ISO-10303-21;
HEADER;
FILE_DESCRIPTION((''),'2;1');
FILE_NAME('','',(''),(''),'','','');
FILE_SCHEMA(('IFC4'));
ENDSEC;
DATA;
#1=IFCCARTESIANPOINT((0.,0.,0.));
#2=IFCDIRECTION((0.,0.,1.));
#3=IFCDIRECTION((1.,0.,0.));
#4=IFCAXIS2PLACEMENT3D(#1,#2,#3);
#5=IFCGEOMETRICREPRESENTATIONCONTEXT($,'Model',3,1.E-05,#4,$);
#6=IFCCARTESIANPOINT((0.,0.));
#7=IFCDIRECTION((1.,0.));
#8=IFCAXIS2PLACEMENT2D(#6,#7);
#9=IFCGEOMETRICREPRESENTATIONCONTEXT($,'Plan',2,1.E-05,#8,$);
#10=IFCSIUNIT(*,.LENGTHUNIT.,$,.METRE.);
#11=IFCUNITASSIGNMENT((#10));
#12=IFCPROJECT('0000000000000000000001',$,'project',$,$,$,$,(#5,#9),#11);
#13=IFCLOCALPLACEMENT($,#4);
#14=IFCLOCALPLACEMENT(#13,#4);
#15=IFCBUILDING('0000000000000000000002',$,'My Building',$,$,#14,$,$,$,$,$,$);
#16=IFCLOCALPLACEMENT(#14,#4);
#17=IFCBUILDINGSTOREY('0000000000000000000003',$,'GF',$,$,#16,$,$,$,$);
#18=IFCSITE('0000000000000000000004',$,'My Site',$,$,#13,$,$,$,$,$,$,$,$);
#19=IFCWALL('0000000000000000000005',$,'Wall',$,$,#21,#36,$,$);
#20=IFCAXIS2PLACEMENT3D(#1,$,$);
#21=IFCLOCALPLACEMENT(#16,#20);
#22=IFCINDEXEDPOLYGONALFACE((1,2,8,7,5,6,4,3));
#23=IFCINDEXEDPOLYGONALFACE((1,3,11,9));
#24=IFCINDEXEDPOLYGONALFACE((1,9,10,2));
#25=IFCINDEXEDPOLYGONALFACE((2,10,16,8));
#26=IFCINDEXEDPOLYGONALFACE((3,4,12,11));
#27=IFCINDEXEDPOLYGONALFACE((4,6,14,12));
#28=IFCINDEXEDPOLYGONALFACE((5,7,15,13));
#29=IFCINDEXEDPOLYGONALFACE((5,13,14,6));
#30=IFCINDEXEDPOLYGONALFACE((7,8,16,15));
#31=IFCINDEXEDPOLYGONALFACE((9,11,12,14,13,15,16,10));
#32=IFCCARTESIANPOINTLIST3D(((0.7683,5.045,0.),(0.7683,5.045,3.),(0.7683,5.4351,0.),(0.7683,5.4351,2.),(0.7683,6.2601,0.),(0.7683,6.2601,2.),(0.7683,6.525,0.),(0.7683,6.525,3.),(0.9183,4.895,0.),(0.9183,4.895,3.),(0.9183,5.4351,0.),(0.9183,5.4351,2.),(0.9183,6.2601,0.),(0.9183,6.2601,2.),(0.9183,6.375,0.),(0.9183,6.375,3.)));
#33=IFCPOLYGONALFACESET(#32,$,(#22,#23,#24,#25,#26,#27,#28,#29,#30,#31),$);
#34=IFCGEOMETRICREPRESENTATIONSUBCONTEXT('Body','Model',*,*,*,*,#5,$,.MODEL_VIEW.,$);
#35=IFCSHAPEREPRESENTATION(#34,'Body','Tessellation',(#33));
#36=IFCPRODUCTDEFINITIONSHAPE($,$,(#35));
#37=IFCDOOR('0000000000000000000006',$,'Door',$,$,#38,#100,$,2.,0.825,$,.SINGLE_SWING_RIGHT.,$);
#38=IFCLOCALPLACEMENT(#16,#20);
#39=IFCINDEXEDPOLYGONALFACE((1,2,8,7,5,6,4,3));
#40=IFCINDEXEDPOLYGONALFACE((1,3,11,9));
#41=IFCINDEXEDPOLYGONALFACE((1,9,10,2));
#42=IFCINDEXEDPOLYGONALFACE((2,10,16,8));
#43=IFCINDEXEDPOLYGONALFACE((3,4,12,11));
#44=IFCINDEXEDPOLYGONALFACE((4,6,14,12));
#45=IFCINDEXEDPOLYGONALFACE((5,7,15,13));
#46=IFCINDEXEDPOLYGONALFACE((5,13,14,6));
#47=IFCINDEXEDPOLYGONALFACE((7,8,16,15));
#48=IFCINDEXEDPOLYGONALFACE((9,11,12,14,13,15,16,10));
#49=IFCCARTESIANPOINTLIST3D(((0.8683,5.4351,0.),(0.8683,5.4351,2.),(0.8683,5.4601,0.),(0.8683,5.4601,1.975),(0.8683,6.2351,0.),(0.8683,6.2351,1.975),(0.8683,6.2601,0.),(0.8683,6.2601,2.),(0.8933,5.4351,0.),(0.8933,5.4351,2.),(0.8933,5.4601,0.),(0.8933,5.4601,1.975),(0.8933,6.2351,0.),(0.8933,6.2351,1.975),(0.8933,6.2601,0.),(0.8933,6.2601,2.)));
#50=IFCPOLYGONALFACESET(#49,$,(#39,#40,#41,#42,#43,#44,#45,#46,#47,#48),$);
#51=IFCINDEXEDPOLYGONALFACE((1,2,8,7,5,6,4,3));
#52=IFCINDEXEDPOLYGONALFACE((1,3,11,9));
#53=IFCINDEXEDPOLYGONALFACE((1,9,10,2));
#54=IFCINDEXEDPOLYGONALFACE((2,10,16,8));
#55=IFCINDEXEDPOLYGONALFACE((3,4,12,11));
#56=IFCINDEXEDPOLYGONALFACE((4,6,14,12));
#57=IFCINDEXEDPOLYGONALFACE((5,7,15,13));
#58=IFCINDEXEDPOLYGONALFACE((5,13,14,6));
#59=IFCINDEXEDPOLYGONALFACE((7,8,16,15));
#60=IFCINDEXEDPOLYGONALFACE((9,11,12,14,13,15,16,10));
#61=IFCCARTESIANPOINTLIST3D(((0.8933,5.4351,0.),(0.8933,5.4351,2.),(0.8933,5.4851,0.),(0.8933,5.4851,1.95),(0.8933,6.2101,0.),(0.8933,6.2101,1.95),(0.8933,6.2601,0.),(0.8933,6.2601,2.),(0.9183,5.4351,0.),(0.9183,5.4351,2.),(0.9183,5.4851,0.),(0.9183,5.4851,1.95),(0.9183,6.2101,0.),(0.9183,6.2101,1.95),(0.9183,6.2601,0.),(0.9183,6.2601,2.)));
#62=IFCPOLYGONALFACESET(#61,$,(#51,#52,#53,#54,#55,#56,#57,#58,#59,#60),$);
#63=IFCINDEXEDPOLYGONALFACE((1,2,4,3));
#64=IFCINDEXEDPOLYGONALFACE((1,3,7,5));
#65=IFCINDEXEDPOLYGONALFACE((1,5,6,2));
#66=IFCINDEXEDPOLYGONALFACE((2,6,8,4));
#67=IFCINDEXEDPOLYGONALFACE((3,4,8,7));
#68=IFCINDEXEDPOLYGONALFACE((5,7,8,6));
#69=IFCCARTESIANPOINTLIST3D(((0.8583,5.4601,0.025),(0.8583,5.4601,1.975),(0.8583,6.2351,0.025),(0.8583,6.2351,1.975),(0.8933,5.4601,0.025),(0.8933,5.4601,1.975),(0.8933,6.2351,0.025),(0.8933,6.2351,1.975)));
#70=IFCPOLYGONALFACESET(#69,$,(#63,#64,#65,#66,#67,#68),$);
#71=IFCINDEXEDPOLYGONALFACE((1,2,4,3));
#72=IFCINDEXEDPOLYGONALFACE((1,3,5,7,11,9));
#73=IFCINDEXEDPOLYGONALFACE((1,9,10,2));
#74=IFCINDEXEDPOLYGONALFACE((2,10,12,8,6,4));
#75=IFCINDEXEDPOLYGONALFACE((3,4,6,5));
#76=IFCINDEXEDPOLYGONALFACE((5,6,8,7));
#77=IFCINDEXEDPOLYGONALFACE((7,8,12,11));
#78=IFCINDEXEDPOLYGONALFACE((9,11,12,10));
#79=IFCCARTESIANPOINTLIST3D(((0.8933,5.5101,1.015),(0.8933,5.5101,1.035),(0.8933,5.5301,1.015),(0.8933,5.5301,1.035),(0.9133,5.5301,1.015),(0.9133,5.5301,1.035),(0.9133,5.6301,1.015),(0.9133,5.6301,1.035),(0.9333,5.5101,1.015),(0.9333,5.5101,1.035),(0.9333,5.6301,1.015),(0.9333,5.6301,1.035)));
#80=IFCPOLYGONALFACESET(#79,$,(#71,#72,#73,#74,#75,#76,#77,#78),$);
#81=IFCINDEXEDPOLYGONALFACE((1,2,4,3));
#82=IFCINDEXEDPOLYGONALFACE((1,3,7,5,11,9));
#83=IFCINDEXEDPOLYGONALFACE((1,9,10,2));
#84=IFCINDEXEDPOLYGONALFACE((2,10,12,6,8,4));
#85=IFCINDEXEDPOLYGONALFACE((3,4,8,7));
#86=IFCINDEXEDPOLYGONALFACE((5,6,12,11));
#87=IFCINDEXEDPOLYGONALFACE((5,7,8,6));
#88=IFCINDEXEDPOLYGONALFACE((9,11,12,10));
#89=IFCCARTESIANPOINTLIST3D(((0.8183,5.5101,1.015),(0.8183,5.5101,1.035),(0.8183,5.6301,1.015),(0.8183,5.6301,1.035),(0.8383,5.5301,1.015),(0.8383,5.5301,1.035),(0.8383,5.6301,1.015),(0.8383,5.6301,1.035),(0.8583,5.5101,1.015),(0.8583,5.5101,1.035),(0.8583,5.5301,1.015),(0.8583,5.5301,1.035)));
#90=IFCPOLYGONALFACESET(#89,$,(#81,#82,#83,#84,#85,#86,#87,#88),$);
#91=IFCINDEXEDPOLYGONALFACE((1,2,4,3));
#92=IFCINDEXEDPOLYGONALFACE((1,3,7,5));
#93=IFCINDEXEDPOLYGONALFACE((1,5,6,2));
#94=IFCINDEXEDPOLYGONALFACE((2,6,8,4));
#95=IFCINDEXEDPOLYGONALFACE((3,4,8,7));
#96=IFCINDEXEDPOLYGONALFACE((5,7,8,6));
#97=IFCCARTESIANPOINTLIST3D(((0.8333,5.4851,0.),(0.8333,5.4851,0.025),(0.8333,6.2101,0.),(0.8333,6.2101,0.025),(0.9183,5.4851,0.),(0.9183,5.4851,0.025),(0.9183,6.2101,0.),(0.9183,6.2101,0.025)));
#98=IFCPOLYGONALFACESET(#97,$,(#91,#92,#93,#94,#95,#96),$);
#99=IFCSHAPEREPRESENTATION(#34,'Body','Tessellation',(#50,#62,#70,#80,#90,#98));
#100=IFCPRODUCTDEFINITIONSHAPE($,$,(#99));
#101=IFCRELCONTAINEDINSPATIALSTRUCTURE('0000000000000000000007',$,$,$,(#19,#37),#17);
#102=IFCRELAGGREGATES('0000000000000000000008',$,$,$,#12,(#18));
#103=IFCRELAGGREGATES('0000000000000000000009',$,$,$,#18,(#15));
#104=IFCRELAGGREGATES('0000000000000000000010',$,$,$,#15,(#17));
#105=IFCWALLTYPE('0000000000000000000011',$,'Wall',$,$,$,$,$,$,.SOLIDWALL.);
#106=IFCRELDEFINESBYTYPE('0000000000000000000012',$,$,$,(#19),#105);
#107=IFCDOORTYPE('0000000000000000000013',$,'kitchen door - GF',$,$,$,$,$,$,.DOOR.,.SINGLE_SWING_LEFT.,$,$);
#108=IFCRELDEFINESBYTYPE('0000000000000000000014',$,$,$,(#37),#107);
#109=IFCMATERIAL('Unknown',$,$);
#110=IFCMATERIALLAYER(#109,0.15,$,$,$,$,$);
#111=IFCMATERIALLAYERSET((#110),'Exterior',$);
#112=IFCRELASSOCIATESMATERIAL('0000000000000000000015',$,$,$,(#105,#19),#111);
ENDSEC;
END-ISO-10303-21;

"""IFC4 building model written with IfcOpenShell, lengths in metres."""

from ifc_helpers import new_model, entity, si_unit, frame, origin_with_axes, origin_2d_with_axis, place, context, subcontext, project, spatial, line, indexed_curve, outline, extrude, shape, source, transform, mapped, material, layer, layer_set, layer_usage, type_object, type_shapes, element, fill, save


model = new_model("IFC4")

# Units and contexts
model_context = context("Model", 3, precision=1e-05, world=origin_with_axes())
plan_context = context("Plan", 2, precision=1e-05, world=origin_2d_with_axis())
body_context_1 = subcontext(model_context, "Body", "Model", "MODEL_VIEW")
body_context_2 = subcontext(plan_context, "Body", "Plan", "PLAN_VIEW")
ifc_project = project(units=[si_unit("LENGTHUNIT", "METRE")], contexts=[model_context, plan_context])

# Site, building, storey
site_placement = place(None, origin_with_axes())
site = spatial("IfcSite", under=ifc_project, at=site_placement, Name="My Site")
building_placement = place(site_placement, origin_with_axes())
building = spatial("IfcBuilding", under=site, at=building_placement, Name="My Building")
storey_placement = place(building_placement, origin_with_axes())
storey = spatial("IfcBuildingStorey", under=building, at=storey_placement, Name="GF")

# Shared definitions
ifc_material = material(Name="Unknown")

# Shared definitions
ifc_layer_1 = layer(ifc_material, 0.15)
ifc_layer_set_1 = layer_set([ifc_layer_1], Name="Exterior")
wall_type_1 = type_object("IfcWallType", Name="Wall", PredefinedType="SOLIDWALL", material=ifc_layer_set_1)

# Wall, opening, door
ifc_layer_usage_1 = layer_usage(ifc_layer_set_1, "AXIS2", "POSITIVE", 0.0)
wall_1_placement = place(storey_placement, frame((0.7683, 6.525, 0.0), z_axis=(0.0, 0.0, 1.0), x_axis=(0.0, -1.0, 0.0)))
wall_1 = element("IfcWall", 1, at=wall_1_placement, inside=storey, type_object=wall_type_1, material=ifc_layer_usage_1, Name="Wall", context=body_context_1, shape_type="SweptSolid", body=[
    extrude(outline(indexed_curve([(0.0, 0.0), (0.15, 0.15), (1.63, 0.15), (1.48, 0.0)], segments=[line(1, 2, 3, 4, 1)])), origin_with_axes(), (0.0, 0.0, 1.0), 3.0),
])
shared_shape_1 = source(origin_with_axes(), body_context_1, "Body", "SweptSolid", [
    extrude(outline(indexed_curve([(0.0, 0.0), (0.825, 0.0), (0.825, 2.0), (0.0, 2.0)], segments=[line(1, 2, 3, 4, 1)])), frame((0.0, -0.6, 0.0), z_axis=(0.0, -1.0, 0.0), x_axis=(1.0, 0.0, 0.0)), (0.0, 0.0, -1.0), 1.2),
])
opening_1_placement = place(wall_1_placement, frame((1.0898, 0.15, 0.0), z_axis=(0.0, 0.0, 1.0), x_axis=(-1.0, 0.0, 0.0)))
opening_1 = element("IfcOpeningElement", 2, at=opening_1_placement, cuts=wall_1, PredefinedType="OPENING", context=body_context_1, shape_type="MappedRepresentation", body=[
    mapped(shared_shape_1, transform((0.0, 0.0, 0.0), x_axis=(1.0, 0.0, 0.0), y_axis=(0.0, 1.0, 0.0), z_axis=(0.0, 0.0, 1.0), scale=1.0)),
])
door_type_1 = type_object("IfcDoorType", Name="kitchen door - GF", OperationType="SINGLE_SWING_LEFT", PredefinedType="DOOR")
shared_shape_2 = source(origin_with_axes(), body_context_1, "Body", "SweptSolid", [
    extrude(outline(indexed_curve([(0.0, 0.0), (0.0, 2.0), (0.825, 2.0), (0.825, 0.0), (0.8, 0.0), (0.8, 1.975), (0.025, 1.975), (0.025, 0.0)], segments=[line(1, 2, 3, 4, 5, 6, 7, 8, 1)])), frame((0.0, 0.025, 0.0), z_axis=(0.0, -1.0, 0.0), x_axis=(1.0, 0.0, 0.0)), (0.0, 0.0, -1.0), 0.025),
    extrude(outline(indexed_curve([(0.0, 0.0), (0.0, 2.0), (0.825, 2.0), (0.825, 0.0), (0.775, 0.0), (0.775, 1.95), (0.05, 1.95), (0.05, 0.0)], segments=[line(1, 2, 3, 4, 5, 6, 7, 8, 1)])), frame((0.0, 0.0, 0.0), z_axis=(0.0, -1.0, 0.0), x_axis=(1.0, 0.0, 0.0)), (0.0, 0.0, -1.0), 0.025),
    extrude(outline(indexed_curve([(0.0, 0.0), (0.775, 0.0), (0.775, 0.035), (0.0, 0.035)], segments=[line(1, 2, 3, 4, 1)])), frame((0.025, 0.025, 0.025), z_axis=(0.0, 0.0, 1.0), x_axis=(1.0, 0.0, 0.0)), (0.0, 0.0, 1.0), 1.95),
    extrude(outline(indexed_curve([(0.0, 0.0), (0.0, -0.04), (0.12, -0.04), (0.12, -0.02), (0.02, -0.02), (0.02, 0.0)], segments=[line(1, 2, 3, 4, 5, 6, 1)])), frame((0.075, 0.025, 1.015), z_axis=(0.0, 0.0, 1.0), x_axis=(1.0, 0.0, 0.0)), (0.0, 0.0, 1.0), 0.02),
    extrude(outline(indexed_curve([(0.0, 0.0), (0.0, 0.04), (0.12, 0.04), (0.12, 0.02), (0.02, 0.02), (0.02, 0.0)], segments=[line(1, 2, 3, 4, 5, 6, 1)])), frame((0.075, 0.06, 1.015), z_axis=(0.0, 0.0, 1.0), x_axis=(1.0, 0.0, 0.0)), (0.0, 0.0, 1.0), 0.02),
    extrude(outline(indexed_curve([(0.0, 0.0), (0.725, 0.0), (0.725, 0.085), (0.0, 0.085)], segments=[line(1, 2, 3, 4, 1)])), frame((0.05, 0.0, 0.0), z_axis=(0.0, 0.0, 1.0), x_axis=(1.0, 0.0, 0.0)), (0.0, 0.0, 1.0), 0.025),
])
shared_shape_3 = source(origin_with_axes(), body_context_2, "Body", "Curve2D", [
    entity("IfcIndexedPolyCurve", entity("IfcCartesianPointList2D", [[0.0, 0.0], [0.0, 0.05], [0.025, 0.05], [0.025, 0.025], [0.05, 0.025], [0.05, 0.0]]), [entity("IfcLineIndex", [1, 2, 3, 4, 5, 6, 1])]),
    entity("IfcIndexedPolyCurve", entity("IfcCartesianPointList2D", [[0.825, 0.0], [0.825, 0.05], [0.8, 0.05], [0.8, 0.025], [0.775, 0.025], [0.775, 0.0]]), [entity("IfcLineIndex", [1, 2, 3, 4, 5, 6, 1])]),
    entity("IfcTrimmedCurve", entity("IfcEllipse", entity("IfcAxis2Placement2D", entity("IfcCartesianPoint", [0.765, 0.05]), entity("IfcDirection", [1.0, 0.0])), 0.74, 0.775), [entity("IfcCartesianPoint", [0.765, 0.825])], [entity("IfcCartesianPoint", [0.025, 0.05])], True, "CARTESIAN"),
    entity("IfcIndexedPolyCurve", entity("IfcCartesianPointList2D", [[0.8, 0.05], [0.765, 0.05], [0.765, 0.825], [0.8, 0.825]]), [entity("IfcLineIndex", [1, 2, 3, 4, 1])]),
])
type_shapes(door_type_1, [shared_shape_2, shared_shape_3])
door_1_placement = place(opening_1_placement, frame((0.0, 0.0, 0.0), z_axis=(0.0, 0.0, 1.0), x_axis=(1.0, 0.0, 0.0)))
door_1 = element("IfcDoor", 3, at=door_1_placement, inside=storey, type_object=door_type_1, Name="Door", OperationType="SINGLE_SWING_RIGHT", OverallHeight=2.0, OverallWidth=0.825, shapes=[
    shape(body_context_1, "Body", "MappedRepresentation", [mapped(shared_shape_2, transform((0.0, 0.0, 0.0), x_axis=(1.0, 0.0, 0.0), y_axis=(0.0, 1.0, 0.0), z_axis=(0.0, 0.0, 1.0), scale=1.0))]),
    shape(body_context_2, "Body", "MappedRepresentation", [mapped(shared_shape_3, transform((0.0, 0.0, 0.0), x_axis=(1.0, 0.0, 0.0), y_axis=(0.0, 1.0, 0.0), z_axis=(0.0, 0.0, 1.0), scale=1.0))]),
])
fill(opening_1, door_1)

save(model, "model.ifc")
